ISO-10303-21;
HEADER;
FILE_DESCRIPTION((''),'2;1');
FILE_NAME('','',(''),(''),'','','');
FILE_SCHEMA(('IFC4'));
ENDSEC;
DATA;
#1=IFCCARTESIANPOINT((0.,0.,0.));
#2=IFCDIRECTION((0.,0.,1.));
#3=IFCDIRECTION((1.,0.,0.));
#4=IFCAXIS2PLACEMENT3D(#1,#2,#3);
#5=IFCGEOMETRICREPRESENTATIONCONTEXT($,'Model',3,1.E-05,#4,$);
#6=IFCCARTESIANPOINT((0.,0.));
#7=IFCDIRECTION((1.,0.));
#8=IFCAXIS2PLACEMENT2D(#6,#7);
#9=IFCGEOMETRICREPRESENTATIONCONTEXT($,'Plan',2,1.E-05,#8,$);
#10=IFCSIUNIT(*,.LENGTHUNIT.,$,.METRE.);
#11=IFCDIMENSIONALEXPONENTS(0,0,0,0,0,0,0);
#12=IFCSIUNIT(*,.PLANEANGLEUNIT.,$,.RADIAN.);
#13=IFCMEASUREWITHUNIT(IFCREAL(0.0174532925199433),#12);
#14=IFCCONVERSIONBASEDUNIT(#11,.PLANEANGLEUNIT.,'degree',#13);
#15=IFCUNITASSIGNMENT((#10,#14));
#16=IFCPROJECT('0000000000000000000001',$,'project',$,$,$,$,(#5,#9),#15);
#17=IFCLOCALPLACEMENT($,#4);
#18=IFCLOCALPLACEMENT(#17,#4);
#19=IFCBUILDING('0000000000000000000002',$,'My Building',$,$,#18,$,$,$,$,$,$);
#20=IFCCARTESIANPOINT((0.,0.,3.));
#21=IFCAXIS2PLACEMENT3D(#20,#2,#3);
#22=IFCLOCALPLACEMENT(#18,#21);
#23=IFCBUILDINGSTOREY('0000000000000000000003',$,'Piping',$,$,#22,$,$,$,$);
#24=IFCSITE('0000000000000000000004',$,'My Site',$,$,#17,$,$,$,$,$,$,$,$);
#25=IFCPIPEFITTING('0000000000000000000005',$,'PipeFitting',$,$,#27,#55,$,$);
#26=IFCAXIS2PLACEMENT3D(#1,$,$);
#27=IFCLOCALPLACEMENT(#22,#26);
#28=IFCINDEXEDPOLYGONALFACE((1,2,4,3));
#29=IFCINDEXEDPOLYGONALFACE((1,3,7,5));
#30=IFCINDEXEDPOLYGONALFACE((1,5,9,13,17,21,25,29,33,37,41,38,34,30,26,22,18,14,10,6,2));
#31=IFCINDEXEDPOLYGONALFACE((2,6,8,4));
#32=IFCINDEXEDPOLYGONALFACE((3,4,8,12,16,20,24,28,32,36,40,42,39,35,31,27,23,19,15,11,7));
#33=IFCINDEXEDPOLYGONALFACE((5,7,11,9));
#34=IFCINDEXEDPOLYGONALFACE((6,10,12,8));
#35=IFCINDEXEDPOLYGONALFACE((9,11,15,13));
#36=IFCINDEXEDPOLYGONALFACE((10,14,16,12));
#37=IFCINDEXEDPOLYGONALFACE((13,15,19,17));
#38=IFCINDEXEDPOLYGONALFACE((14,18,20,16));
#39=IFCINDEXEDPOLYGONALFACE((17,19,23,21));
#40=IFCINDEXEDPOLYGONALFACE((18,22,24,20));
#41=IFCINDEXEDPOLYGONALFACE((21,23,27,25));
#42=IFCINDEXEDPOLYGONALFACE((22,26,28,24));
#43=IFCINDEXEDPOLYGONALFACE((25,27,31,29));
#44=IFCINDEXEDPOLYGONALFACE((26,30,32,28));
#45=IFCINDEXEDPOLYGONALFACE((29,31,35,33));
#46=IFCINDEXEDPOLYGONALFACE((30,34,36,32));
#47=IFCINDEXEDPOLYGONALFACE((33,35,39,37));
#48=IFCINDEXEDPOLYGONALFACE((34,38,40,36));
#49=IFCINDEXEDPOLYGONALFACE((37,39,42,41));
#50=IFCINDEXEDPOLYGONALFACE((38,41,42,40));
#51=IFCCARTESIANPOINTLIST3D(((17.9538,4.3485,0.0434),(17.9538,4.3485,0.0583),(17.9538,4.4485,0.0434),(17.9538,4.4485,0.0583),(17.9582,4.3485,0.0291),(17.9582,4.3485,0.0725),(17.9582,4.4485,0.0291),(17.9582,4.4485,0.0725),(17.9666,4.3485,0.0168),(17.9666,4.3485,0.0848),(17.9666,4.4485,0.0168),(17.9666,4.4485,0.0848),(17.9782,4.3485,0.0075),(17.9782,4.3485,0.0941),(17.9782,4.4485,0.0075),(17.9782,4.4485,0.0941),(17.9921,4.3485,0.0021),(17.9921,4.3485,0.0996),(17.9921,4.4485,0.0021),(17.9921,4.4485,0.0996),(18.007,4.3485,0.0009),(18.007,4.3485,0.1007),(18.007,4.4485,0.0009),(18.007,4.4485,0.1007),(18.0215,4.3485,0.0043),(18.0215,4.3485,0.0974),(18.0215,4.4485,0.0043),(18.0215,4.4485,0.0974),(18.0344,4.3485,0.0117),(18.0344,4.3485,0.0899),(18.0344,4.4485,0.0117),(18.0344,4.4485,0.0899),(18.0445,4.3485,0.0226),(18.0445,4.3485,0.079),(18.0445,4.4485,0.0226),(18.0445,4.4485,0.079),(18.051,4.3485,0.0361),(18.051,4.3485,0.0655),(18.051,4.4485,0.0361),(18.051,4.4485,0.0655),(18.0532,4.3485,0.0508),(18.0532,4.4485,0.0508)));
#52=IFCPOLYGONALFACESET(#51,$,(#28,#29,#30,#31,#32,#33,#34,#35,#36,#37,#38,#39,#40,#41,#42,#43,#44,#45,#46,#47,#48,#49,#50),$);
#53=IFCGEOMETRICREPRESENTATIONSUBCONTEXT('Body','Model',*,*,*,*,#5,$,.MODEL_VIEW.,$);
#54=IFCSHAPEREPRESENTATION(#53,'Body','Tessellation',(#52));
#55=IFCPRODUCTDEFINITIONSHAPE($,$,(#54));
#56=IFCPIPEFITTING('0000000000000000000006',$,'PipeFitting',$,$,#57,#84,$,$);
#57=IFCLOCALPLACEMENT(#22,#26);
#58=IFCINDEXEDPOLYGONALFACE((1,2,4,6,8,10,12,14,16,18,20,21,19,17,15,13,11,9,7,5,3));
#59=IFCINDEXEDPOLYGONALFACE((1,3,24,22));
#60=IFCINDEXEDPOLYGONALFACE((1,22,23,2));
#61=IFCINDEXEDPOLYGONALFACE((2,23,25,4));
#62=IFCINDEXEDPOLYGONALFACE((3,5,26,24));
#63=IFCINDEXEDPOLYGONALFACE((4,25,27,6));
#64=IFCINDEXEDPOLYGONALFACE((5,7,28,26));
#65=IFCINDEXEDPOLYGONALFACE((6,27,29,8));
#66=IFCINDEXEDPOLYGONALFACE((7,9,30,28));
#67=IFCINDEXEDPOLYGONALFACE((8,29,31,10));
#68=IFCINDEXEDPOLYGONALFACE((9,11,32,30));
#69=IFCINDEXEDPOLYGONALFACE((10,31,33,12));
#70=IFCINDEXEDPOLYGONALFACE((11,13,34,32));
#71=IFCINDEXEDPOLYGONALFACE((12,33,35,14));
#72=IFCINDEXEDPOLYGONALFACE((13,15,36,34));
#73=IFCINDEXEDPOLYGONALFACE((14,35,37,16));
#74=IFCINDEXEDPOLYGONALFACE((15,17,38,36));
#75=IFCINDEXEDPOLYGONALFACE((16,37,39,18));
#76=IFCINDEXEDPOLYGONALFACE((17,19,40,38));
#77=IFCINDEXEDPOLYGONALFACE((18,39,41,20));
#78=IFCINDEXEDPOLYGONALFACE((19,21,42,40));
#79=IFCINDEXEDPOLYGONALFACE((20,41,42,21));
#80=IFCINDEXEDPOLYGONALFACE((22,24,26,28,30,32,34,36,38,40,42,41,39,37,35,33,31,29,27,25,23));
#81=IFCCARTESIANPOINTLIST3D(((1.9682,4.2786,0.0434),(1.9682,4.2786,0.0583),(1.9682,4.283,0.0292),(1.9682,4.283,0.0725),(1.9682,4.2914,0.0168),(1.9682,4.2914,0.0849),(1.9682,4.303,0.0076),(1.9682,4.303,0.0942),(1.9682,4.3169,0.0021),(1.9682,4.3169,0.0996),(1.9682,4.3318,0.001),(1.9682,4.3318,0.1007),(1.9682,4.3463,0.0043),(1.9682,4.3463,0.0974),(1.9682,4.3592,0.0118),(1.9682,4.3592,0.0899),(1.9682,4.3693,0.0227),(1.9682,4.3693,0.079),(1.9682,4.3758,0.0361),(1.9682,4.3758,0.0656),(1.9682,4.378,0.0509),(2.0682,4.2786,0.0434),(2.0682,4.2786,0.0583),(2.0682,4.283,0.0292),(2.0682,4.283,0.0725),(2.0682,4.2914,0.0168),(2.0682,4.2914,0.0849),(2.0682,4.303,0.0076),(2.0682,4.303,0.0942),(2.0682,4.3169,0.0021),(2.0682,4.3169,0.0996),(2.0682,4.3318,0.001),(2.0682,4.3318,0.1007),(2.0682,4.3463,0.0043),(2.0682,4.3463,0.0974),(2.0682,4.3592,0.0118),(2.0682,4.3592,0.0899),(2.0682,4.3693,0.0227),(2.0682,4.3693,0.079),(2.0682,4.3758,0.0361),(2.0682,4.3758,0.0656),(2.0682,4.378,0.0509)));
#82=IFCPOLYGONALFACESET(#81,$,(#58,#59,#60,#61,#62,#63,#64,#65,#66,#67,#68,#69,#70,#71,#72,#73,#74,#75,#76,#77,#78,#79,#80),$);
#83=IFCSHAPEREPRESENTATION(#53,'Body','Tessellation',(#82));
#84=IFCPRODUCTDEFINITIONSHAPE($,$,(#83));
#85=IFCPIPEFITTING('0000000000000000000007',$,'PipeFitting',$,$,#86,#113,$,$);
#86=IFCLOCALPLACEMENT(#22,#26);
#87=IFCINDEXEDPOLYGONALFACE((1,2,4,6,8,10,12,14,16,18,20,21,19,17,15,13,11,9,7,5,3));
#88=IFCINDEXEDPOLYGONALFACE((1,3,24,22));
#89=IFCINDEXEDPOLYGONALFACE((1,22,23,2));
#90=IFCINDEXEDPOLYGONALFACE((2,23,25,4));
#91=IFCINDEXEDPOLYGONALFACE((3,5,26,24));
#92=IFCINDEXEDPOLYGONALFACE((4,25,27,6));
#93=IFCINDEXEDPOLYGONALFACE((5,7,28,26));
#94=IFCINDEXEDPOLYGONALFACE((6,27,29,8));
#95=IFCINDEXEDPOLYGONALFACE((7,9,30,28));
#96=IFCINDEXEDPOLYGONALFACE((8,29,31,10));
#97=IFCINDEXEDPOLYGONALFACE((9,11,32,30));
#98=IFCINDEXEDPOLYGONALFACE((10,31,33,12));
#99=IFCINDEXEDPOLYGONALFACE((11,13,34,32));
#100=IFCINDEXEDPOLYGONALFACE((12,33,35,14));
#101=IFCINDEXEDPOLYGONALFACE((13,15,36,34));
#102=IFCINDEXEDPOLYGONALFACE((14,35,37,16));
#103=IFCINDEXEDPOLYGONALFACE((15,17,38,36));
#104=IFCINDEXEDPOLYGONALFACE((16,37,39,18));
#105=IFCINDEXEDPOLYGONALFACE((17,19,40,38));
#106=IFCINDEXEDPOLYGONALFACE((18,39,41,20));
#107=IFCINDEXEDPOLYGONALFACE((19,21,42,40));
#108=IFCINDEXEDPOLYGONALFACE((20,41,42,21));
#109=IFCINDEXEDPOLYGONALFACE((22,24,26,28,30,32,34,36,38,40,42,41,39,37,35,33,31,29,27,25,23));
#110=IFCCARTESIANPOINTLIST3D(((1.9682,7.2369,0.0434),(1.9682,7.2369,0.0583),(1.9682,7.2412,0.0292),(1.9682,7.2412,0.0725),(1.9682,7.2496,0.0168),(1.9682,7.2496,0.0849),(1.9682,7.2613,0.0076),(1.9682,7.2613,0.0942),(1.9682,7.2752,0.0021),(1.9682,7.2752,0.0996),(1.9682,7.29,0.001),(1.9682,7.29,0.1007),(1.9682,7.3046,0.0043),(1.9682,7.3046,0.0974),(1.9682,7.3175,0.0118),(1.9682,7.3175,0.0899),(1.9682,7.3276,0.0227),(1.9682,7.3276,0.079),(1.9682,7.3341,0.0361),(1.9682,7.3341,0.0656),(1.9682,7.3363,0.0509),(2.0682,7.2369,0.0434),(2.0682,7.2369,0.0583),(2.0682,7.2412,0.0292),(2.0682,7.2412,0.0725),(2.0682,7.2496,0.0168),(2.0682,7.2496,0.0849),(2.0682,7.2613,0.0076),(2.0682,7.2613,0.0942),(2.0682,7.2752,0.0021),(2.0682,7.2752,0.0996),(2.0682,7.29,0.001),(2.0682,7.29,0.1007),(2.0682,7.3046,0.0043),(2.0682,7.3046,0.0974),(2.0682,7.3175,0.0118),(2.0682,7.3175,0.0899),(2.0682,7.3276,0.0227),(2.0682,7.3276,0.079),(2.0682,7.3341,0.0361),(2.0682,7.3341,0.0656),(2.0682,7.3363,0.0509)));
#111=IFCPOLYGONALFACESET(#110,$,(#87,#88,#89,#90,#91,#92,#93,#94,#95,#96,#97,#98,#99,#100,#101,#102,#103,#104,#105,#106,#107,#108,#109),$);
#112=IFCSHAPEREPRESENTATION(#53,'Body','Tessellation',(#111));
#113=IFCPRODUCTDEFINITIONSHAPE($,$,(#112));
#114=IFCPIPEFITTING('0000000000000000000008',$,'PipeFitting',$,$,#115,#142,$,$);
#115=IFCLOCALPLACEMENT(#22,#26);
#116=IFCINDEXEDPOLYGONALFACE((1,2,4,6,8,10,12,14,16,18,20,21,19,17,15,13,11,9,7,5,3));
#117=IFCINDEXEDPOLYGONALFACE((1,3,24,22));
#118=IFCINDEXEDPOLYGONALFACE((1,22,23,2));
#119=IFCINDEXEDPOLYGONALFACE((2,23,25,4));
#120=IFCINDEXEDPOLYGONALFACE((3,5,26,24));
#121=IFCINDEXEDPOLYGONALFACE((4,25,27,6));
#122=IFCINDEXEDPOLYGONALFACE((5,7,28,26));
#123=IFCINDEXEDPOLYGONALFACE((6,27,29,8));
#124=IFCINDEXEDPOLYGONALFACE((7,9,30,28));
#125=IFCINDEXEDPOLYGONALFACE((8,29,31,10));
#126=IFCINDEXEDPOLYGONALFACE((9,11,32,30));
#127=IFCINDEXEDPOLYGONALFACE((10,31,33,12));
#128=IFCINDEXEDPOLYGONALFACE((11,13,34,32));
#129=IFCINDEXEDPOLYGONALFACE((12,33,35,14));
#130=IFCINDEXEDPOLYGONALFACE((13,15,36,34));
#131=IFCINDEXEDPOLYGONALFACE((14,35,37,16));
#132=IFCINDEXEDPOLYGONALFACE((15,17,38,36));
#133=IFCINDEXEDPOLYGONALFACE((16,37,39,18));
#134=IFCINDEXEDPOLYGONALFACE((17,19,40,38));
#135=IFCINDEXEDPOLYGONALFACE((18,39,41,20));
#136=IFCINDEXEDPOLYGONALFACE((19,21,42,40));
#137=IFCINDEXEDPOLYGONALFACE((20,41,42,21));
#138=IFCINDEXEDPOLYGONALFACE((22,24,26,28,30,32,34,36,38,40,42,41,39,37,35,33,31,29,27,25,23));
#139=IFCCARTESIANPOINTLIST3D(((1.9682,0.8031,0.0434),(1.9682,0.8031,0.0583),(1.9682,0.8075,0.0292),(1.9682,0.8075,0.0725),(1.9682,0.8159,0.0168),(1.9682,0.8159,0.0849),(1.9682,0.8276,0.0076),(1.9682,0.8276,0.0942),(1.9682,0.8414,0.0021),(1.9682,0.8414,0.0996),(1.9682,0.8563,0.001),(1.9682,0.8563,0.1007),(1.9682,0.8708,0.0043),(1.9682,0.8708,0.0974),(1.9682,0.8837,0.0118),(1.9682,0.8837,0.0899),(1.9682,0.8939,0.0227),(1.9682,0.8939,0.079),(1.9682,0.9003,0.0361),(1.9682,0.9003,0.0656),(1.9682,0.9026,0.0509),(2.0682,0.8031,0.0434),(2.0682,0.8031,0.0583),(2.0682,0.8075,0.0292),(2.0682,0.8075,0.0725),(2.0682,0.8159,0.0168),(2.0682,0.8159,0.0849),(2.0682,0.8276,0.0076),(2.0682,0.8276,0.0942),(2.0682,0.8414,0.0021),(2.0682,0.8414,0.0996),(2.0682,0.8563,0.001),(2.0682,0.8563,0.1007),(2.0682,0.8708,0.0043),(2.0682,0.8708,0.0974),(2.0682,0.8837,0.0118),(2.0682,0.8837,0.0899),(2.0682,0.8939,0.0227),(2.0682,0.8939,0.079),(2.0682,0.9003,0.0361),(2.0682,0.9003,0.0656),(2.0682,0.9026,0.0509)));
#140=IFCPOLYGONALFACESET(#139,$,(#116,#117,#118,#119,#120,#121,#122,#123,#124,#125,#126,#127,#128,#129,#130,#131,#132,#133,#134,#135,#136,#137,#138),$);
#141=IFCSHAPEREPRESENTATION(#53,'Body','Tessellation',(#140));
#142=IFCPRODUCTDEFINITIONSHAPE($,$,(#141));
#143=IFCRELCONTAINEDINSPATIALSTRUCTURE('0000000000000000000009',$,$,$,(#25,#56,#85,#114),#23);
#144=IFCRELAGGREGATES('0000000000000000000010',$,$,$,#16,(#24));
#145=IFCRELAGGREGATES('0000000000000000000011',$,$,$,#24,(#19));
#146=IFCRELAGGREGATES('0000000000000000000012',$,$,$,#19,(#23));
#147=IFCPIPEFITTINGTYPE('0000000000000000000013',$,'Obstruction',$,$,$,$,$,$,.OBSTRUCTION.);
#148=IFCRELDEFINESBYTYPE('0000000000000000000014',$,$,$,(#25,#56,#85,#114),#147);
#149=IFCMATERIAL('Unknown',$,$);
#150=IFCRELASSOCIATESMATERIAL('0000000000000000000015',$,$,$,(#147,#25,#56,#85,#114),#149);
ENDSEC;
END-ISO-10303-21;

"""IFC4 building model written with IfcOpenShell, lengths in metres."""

from ifc_helpers import new_model, entity, si_unit, converted_unit, frame, origin_with_axes, origin_2d_with_axis, place, context, subcontext, project, spatial, circle, extrude, material, material_profile, profile_set, profile_usage, type_object, element, save


model = new_model("IFC4")

# Units and contexts
model_context = context("Model", 3, precision=1e-05, world=origin_with_axes())
plan_context = context("Plan", 2, precision=1e-05, world=origin_2d_with_axis())
body_context = subcontext(model_context, "Body", "Model", "MODEL_VIEW")
ifc_project = project(units=[si_unit("LENGTHUNIT", "METRE"), converted_unit("PLANEANGLEUNIT", "degree", entity("IfcReal", 0.0174532925199433), si_unit("PLANEANGLEUNIT", "RADIAN"), dimensions=[0, 0, 0, 0, 0, 0, 0])], contexts=[model_context, plan_context])

# Site, building, storey
site_placement = place(None, origin_with_axes())
site = spatial("IfcSite", under=ifc_project, at=site_placement, Name="My Site")
building_placement = place(site_placement, origin_with_axes())
building = spatial("IfcBuilding", under=site, at=building_placement, Name="My Building")
storey_placement = place(building_placement, frame((0.0, 0.0, 3.0), z_axis=(0.0, 0.0, 1.0), x_axis=(1.0, 0.0, 0.0)))
storey = spatial("IfcBuildingStorey", under=building, at=storey_placement, Name="Piping")

# Shared definitions
ifc_material = material(Name="Unknown")

# Pipe fittings
ifc_material_profile_1 = material_profile(ifc_material, circle(Radius=0.05))
ifc_profile_set_1 = profile_set([ifc_material_profile_1])
pipe_fitting_type = type_object("IfcPipeFittingType", Name="Obstruction", PredefinedType="OBSTRUCTION", material=ifc_profile_set_1)
ifc_profile_usage_1 = profile_usage(ifc_profile_set_1, cardinal=5)
pipe_fitting_1_placement = place(storey_placement, frame((18.0032, 4.3485, 0.0508), z_axis=(0.0, 1.0, 0.0), x_axis=(1.0, 0.0, 0.0)))
element("IfcPipeFitting", 1, at=pipe_fitting_1_placement, inside=storey, type_object=pipe_fitting_type, material=ifc_profile_usage_1, Name="PipeFitting", context=body_context, shape_type="SweptSolid", body=[
    extrude(circle(Radius=0.05), origin_with_axes(), (0.0, 0.0, 1.0), 0.1),
])
ifc_profile_usage_2 = profile_usage(ifc_profile_set_1, cardinal=5)
pipe_fitting_2_placement = place(storey_placement, frame((1.9682, 4.328, 0.0509), z_axis=(1.0, 0.0, 0.0), x_axis=(0.0, 1.0, 0.0)))
element("IfcPipeFitting", 2, at=pipe_fitting_2_placement, inside=storey, type_object=pipe_fitting_type, material=ifc_profile_usage_2, Name="PipeFitting", context=body_context, shape_type="SweptSolid", body=[
    extrude(circle(Radius=0.05), origin_with_axes(), (0.0, 0.0, 1.0), 0.1),
])
ifc_profile_usage_3 = profile_usage(ifc_profile_set_1, cardinal=5)
pipe_fitting_3_placement = place(storey_placement, frame((1.9682, 7.2863, 0.0509), z_axis=(1.0, 0.0, 0.0), x_axis=(0.0, 1.0, 0.0)))
element("IfcPipeFitting", 3, at=pipe_fitting_3_placement, inside=storey, type_object=pipe_fitting_type, material=ifc_profile_usage_3, Name="PipeFitting", context=body_context, shape_type="SweptSolid", body=[
    extrude(circle(Radius=0.05), origin_with_axes(), (0.0, 0.0, 1.0), 0.1),
])
ifc_profile_usage_4 = profile_usage(ifc_profile_set_1, cardinal=5)
pipe_fitting_4_placement = place(storey_placement, frame((1.9682, 0.8526, 0.0509), z_axis=(1.0, 0.0, 0.0), x_axis=(0.0, 1.0, 0.0)))
element("IfcPipeFitting", 4, at=pipe_fitting_4_placement, inside=storey, type_object=pipe_fitting_type, material=ifc_profile_usage_4, Name="PipeFitting", context=body_context, shape_type="SweptSolid", body=[
    extrude(circle(Radius=0.05), origin_with_axes(), (0.0, 0.0, 1.0), 0.1),
])

save(model, "model.ifc")
